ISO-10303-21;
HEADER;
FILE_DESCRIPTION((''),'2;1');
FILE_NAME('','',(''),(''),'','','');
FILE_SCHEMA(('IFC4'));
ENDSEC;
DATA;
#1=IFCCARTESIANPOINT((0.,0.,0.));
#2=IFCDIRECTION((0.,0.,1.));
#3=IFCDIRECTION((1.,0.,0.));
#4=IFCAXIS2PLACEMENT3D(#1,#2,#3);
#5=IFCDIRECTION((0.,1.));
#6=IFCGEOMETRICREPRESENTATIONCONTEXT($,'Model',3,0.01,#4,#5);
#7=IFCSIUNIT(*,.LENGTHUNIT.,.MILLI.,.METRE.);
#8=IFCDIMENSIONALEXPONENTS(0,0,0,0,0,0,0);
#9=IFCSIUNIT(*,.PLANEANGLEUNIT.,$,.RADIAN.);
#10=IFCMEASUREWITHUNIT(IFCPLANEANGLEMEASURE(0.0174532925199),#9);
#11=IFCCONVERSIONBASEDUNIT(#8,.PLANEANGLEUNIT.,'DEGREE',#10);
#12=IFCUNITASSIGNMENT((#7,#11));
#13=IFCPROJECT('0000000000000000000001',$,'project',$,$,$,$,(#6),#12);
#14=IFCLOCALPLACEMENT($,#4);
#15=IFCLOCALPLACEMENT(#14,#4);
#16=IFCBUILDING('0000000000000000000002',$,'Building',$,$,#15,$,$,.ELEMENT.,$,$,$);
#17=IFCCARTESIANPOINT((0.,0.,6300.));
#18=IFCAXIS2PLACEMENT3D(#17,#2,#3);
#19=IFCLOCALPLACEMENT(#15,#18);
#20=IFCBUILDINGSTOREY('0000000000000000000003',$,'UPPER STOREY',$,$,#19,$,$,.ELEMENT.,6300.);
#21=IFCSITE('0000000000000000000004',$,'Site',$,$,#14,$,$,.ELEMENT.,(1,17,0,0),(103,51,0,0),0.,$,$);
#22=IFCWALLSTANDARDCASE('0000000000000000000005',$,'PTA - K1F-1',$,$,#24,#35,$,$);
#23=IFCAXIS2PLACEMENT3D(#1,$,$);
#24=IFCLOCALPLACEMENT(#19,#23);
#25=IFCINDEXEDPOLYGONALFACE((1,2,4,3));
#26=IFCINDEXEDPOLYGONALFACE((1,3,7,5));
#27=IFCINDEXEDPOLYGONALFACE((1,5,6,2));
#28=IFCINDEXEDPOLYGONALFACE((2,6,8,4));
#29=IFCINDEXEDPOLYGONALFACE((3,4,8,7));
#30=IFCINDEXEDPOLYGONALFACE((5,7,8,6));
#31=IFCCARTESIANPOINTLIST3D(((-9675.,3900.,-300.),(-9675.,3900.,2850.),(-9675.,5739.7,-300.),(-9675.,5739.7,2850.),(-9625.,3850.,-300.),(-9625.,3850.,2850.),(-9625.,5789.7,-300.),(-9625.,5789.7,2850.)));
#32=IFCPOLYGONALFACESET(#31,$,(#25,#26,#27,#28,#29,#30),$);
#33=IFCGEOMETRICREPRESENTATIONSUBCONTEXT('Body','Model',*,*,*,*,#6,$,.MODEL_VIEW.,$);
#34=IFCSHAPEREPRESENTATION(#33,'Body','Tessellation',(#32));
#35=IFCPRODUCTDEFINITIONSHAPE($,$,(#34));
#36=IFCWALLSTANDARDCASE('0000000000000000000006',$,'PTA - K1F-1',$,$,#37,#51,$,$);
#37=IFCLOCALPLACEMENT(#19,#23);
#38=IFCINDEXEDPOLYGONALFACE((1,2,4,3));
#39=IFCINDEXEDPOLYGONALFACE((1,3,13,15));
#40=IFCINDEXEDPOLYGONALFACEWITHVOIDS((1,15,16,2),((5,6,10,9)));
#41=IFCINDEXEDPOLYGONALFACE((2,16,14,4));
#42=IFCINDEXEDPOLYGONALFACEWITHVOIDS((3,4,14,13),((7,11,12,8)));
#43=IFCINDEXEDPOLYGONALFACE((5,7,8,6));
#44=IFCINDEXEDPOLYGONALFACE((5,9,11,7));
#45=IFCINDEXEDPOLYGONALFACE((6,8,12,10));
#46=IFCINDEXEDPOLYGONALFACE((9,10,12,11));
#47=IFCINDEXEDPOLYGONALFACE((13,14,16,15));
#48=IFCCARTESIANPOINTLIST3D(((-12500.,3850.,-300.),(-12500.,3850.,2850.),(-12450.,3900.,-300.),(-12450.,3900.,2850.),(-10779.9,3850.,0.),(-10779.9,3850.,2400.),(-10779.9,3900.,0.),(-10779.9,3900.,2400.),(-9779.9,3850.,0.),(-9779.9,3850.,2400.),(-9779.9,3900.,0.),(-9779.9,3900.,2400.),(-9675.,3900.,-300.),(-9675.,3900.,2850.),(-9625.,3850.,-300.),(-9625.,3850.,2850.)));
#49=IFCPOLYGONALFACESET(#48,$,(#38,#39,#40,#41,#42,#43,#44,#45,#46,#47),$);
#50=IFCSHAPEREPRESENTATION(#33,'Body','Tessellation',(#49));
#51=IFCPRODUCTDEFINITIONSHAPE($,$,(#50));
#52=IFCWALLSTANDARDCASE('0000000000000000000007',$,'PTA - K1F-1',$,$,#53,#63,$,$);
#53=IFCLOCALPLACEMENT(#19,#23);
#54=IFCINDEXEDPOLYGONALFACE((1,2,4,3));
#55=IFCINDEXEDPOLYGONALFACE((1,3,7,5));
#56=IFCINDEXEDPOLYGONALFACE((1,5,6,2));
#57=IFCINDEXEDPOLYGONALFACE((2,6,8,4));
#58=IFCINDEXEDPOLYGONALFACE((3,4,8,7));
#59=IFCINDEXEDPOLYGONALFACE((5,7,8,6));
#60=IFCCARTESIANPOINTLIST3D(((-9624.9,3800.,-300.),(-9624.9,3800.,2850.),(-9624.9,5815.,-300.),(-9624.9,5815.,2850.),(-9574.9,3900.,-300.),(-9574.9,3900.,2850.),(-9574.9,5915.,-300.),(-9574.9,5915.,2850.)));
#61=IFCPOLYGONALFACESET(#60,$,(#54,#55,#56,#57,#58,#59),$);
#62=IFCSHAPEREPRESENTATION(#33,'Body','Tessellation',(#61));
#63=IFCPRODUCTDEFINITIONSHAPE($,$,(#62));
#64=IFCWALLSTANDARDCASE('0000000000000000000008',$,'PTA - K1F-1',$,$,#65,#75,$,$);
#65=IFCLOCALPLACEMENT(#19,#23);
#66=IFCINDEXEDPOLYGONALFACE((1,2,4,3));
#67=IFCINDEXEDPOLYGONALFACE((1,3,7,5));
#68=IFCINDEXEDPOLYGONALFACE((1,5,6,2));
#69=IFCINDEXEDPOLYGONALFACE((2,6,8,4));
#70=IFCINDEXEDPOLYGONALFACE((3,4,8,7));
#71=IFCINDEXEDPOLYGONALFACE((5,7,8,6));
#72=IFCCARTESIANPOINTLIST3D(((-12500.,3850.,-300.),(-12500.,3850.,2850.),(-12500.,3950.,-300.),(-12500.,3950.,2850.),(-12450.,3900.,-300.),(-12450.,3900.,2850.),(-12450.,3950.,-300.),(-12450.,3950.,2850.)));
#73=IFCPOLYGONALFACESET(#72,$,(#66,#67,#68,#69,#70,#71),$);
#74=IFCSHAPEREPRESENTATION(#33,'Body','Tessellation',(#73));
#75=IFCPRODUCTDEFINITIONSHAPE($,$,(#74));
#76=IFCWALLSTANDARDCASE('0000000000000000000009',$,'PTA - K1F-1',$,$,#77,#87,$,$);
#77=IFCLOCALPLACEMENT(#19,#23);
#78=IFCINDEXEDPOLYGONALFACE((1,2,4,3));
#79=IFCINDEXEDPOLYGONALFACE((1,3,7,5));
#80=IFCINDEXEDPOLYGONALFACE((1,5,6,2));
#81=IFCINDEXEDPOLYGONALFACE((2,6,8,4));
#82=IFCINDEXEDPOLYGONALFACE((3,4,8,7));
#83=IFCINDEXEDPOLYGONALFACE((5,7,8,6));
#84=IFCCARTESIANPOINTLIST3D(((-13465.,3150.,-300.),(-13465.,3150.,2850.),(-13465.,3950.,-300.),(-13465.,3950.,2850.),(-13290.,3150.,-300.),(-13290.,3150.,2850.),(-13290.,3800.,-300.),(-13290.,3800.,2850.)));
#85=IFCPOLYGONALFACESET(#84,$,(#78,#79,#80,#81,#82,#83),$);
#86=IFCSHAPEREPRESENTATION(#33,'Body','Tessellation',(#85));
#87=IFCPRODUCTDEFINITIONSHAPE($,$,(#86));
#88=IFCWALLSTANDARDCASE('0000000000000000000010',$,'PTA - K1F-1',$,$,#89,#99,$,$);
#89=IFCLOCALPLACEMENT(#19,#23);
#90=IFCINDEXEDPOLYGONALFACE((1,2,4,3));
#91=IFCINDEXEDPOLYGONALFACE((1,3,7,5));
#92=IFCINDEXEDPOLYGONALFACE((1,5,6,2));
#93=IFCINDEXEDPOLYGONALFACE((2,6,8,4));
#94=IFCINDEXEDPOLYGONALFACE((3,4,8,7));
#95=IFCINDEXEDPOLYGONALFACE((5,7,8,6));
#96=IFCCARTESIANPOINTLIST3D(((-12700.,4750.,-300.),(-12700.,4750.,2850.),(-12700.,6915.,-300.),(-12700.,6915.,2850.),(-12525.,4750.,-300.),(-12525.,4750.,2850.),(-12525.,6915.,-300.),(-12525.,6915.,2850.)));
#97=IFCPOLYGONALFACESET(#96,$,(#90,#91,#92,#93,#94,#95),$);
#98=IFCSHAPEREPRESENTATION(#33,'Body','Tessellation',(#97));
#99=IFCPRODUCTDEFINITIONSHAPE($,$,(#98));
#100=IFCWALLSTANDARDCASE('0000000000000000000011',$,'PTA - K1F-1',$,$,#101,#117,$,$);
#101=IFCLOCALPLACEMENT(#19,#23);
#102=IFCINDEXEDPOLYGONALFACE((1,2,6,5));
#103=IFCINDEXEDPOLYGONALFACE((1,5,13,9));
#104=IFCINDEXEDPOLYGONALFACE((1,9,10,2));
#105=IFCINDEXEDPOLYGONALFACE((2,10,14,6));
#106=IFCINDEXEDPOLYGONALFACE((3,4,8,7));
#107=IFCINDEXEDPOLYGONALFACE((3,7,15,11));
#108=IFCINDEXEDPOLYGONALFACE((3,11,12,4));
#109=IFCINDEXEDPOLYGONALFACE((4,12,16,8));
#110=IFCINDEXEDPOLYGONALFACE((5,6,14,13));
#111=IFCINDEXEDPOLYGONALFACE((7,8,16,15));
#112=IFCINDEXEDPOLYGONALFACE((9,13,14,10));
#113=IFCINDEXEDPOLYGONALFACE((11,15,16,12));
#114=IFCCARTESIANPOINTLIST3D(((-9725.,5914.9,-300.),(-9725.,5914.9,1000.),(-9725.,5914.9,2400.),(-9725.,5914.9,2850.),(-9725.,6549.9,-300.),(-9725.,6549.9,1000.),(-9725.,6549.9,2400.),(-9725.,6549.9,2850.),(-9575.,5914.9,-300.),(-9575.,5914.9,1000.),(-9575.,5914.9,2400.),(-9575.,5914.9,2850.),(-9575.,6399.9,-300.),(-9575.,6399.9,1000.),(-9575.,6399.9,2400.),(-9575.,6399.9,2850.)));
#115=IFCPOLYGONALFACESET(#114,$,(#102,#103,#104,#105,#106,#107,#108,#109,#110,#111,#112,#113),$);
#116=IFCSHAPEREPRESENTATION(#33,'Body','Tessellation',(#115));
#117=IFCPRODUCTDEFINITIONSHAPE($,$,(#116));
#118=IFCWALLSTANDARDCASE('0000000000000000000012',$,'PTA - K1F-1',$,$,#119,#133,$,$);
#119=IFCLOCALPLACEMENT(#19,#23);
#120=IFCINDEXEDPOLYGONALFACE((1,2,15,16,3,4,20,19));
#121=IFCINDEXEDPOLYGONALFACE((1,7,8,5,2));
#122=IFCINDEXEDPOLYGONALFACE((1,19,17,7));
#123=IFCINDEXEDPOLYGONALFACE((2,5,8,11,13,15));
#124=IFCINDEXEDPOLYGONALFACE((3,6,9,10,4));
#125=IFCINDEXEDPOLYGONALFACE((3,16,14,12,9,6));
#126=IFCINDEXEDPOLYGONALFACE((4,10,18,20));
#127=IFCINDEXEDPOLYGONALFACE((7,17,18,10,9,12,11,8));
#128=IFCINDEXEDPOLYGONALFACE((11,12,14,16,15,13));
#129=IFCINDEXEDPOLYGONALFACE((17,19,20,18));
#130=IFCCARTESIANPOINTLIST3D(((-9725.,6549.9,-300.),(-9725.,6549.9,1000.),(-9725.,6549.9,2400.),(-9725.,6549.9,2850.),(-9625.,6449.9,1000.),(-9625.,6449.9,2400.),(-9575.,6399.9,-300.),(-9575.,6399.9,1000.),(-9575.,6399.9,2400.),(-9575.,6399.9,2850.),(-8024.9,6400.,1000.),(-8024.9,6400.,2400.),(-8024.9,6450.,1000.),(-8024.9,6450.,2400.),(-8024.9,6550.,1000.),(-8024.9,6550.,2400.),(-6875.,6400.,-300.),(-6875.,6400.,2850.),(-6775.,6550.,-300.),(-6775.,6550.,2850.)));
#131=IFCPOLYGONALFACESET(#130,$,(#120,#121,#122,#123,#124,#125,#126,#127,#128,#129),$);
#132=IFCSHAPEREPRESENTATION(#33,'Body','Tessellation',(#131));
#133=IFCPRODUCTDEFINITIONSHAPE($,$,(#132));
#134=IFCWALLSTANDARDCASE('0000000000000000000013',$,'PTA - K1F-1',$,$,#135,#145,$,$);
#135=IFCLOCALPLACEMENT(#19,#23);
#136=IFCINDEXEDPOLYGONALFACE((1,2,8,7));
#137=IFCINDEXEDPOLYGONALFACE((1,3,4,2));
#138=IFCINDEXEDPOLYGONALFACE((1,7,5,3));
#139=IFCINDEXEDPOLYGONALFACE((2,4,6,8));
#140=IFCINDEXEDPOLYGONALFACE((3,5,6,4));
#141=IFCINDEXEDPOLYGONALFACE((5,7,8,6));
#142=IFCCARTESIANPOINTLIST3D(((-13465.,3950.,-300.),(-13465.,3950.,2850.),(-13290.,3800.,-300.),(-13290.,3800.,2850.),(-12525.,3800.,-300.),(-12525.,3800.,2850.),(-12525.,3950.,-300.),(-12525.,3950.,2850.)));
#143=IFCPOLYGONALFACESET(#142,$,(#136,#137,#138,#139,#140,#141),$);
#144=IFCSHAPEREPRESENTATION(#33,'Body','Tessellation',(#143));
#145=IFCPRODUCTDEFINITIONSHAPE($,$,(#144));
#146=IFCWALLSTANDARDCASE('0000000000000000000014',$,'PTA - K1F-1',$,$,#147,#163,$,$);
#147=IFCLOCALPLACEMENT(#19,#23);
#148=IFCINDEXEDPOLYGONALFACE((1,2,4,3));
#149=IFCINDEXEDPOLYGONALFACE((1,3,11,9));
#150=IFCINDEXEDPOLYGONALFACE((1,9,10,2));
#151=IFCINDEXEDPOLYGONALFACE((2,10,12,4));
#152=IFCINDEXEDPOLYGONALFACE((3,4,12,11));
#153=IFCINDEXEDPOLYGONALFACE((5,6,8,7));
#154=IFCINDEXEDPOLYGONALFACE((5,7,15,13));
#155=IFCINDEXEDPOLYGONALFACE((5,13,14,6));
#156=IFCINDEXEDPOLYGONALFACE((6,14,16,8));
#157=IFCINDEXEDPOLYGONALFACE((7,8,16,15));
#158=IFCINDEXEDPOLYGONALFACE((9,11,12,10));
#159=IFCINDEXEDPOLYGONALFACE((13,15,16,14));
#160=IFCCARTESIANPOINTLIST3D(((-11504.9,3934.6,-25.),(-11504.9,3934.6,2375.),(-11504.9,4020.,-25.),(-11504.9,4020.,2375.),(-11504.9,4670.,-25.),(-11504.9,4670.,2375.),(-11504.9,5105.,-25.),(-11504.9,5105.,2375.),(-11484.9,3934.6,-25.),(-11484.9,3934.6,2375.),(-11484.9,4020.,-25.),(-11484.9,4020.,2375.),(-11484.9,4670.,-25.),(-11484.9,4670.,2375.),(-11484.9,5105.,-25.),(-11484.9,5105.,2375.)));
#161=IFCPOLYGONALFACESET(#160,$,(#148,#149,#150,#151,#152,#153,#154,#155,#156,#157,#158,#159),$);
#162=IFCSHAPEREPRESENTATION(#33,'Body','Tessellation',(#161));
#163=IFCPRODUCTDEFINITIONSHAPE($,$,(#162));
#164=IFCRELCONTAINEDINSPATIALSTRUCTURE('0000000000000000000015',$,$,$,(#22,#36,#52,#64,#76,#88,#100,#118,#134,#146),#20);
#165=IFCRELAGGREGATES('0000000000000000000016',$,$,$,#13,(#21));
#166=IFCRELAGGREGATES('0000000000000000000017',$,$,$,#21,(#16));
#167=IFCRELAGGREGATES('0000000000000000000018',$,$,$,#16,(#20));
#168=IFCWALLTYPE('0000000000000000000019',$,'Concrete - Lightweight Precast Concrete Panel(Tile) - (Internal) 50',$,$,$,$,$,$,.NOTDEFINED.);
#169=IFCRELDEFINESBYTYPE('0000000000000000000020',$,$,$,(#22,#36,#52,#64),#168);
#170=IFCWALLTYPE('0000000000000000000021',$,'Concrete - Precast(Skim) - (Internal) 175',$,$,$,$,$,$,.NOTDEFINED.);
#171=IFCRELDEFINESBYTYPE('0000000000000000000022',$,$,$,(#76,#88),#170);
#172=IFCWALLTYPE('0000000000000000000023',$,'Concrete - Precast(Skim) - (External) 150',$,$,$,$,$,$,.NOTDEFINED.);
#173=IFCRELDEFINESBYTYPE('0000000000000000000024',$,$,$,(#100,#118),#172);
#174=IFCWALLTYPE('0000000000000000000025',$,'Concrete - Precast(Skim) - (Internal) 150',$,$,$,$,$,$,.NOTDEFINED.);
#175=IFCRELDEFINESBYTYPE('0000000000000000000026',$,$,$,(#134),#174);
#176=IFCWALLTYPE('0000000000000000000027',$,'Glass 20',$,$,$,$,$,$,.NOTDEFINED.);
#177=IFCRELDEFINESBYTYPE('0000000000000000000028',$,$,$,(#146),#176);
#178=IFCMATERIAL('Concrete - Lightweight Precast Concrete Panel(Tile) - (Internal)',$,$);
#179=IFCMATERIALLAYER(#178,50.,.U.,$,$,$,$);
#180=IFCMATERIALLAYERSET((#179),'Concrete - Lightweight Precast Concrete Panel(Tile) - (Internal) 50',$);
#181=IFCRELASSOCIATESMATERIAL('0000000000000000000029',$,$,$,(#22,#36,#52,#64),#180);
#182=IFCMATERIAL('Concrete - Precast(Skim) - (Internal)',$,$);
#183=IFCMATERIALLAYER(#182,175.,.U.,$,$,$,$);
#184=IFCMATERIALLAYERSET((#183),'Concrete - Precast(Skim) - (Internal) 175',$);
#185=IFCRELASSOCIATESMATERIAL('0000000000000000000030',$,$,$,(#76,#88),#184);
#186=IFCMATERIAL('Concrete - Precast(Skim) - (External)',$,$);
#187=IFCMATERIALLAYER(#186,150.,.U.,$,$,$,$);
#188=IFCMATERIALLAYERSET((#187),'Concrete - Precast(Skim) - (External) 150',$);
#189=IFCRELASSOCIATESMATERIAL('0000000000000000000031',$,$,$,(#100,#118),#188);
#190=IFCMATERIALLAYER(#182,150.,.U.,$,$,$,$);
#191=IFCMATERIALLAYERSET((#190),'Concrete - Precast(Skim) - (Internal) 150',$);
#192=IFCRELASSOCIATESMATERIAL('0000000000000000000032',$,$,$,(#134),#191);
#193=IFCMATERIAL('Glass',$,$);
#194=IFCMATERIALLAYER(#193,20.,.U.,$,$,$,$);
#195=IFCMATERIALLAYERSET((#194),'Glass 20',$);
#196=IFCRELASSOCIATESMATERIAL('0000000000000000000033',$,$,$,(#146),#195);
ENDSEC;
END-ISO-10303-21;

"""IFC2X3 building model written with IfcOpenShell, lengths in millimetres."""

from ifc_helpers import new_model, entity, si_unit, converted_unit, direction, frame, origin_with_axes, origin_2d_with_axis, place, context, subcontext, project, spatial, polyline, rectangle, outline, extrude, material, layer, layer_set, layer_usage, type_object, element, save


model = new_model("IFC2X3")

# Units and contexts
model_context = context("Model", 3, precision=0.01, world=origin_with_axes(), true_north=direction((0.0, 1.0)))
body_context = subcontext(model_context, "Body", "Model", "MODEL_VIEW")
ifc_project = project(units=[si_unit("LENGTHUNIT", "METRE", prefix="MILLI"), converted_unit("PLANEANGLEUNIT", "DEGREE", entity("IfcPlaneAngleMeasure", 0.0174532925199), si_unit("PLANEANGLEUNIT", "RADIAN"), dimensions=[0, 0, 0, 0, 0, 0, 0])], contexts=[model_context])

# Site, building, storey
site_placement = place(None, origin_with_axes())
site = spatial("IfcSite", under=ifc_project, at=site_placement, Name="Site", CompositionType="ELEMENT", RefLatitude=(1, 17, 0, 0), RefLongitude=(103, 51, 0, 0), RefElevation=0.0)
building_placement = place(site_placement, origin_with_axes())
building = spatial("IfcBuilding", under=site, at=building_placement, Name="Building", CompositionType="ELEMENT")
storey_placement = place(building_placement, frame((0.0, 0.0, 6300.0), z_axis=(0.0, 0.0, 1.0), x_axis=(1.0, 0.0, 0.0)))
storey = spatial("IfcBuildingStorey", under=building, at=storey_placement, Name="UPPER STOREY", CompositionType="ELEMENT", Elevation=6300.0)

# Wall
ifc_material_1 = material(Name="Concrete - Lightweight Precast Concrete Panel(Tile) - (Internal)")
ifc_layer_1 = layer(ifc_material_1, 50.0, ventilated="UNKNOWN")
ifc_layer_set_1 = layer_set([ifc_layer_1], Name="Concrete - Lightweight Precast Concrete Panel(Tile) - (Internal) 50")
wall_type_1 = type_object("IfcWallType", Name="Concrete - Lightweight Precast Concrete Panel(Tile) - (Internal) 50", PredefinedType="NOTDEFINED")
ifc_layer_usage_1 = layer_usage(ifc_layer_set_1, "AXIS2", "POSITIVE", 0.0)
wall_1_placement = place(storey_placement, frame((-9675.0, 5789.7, -300.0), z_axis=(0.0, 0.0, 1.0), x_axis=(0.0, -1.0, 0.0)))
element("IfcWallStandardCase", 1, at=wall_1_placement, inside=storey, type_object=wall_type_1, material=ifc_layer_usage_1, Name="PTA - K1F-1", context=body_context, shape_type="SweptSolid", body=[
    extrude(outline(polyline([(50.0, 0.0), (1889.7, 0.0), (1939.7, 50.0), (0.0, 50.0), (50.0, 0.0)])), origin_with_axes(), (0.0, 0.0, 1.0), 3150.0),
])

# Wall, opening
ifc_layer_usage_2 = layer_usage(ifc_layer_set_1, "AXIS2", "NEGATIVE", 0.0)
wall_2_placement = place(storey_placement, frame((-9675.0, 3850.0, -300.0), z_axis=(0.0, 0.0, 1.0), x_axis=(-1.0, 0.000001, 0.0)))
wall_2 = element("IfcWallStandardCase", 2, at=wall_2_placement, inside=storey, type_object=wall_type_1, material=ifc_layer_usage_2, Name="PTA - K1F-1", context=body_context, shape_type="SweptSolid", body=[
    extrude(outline(polyline([(0.0, -50.0), (2775.0, -50.0), (2825.0, 0.0), (-50.0, 0.0), (0.0, -50.0)])), origin_with_axes(), (0.0, 0.0, 1.0), 3150.0),
])
opening_1_placement = place(wall_2_placement, frame((604.9, 0.0, 300.0), z_axis=(0.0, 0.0, 1.0), x_axis=(1.0, 0.0, 0.0)))
element("IfcOpeningElement", 3, at=opening_1_placement, cuts=wall_2, context=body_context, shape_type="SweptSolid", body=[
    extrude(rectangle(XDim=1000.0, YDim=2400.0, at=origin_2d_with_axis()), frame((0.0, 50.0, 1200.0), z_axis=(0.0, -1.0, 0.0), x_axis=(-1.0, 0.0, 0.0)), (0.0, 0.0, 1.0), 150.0),
])

# Walls
ifc_layer_usage_3 = layer_usage(ifc_layer_set_1, "AXIS2", "NEGATIVE", 0.0)
wall_3_placement = place(storey_placement, frame((-9574.9, 5915.0, -300.0), z_axis=(0.0, 0.0, 1.0), x_axis=(0.0, -1.0, 0.0)))
element("IfcWallStandardCase", 4, at=wall_3_placement, inside=storey, type_object=wall_type_1, material=ifc_layer_usage_3, Name="PTA - K1F-1", context=body_context, shape_type="SweptSolid", body=[
    extrude(outline(polyline([(100.0, -50.0), (2115.0, -50.0), (2015.0, 0.0), (0.0, 0.0), (100.0, -50.0)])), origin_with_axes(), (0.0, 0.0, 1.0), 3150.0),
])
ifc_layer_usage_4 = layer_usage(ifc_layer_set_1, "AXIS2", "NEGATIVE", 0.0)
wall_4_placement = place(storey_placement, frame((-12500.0, 3850.0, -300.0), z_axis=(0.0, 0.0, 1.0), x_axis=(0.0, 1.0, 0.0)))
element("IfcWallStandardCase", 5, at=wall_4_placement, inside=storey, type_object=wall_type_1, material=ifc_layer_usage_4, Name="PTA - K1F-1", context=body_context, shape_type="SweptSolid", body=[
    extrude(outline(polyline([(50.0, -50.0), (100.0, -50.0), (100.0, 0.0), (0.0, 0.0), (50.0, -50.0)])), origin_with_axes(), (0.0, 0.0, 1.0), 3150.0),
])
ifc_material_2 = material(Name="Concrete - Precast(Skim) - (Internal)")
ifc_layer_2 = layer(ifc_material_2, 175.0, ventilated="UNKNOWN")
ifc_layer_set_2 = layer_set([ifc_layer_2], Name="Concrete - Precast(Skim) - (Internal) 175")
ifc_layer_usage_5 = layer_usage(ifc_layer_set_2, "AXIS2", "NEGATIVE", 0.0)
wall_type_2 = type_object("IfcWallType", Name="Concrete - Precast(Skim) - (Internal) 175", PredefinedType="NOTDEFINED")
wall_5_placement = place(storey_placement, frame((-13465.0, 3150.0, -300.0), z_axis=(0.0, 0.0, 1.0), x_axis=(0.0, 1.0, 0.0)))
element("IfcWallStandardCase", 6, at=wall_5_placement, inside=storey, type_object=wall_type_2, material=ifc_layer_usage_5, Name="PTA - K1F-1", context=body_context, shape_type="SweptSolid", body=[
    extrude(outline(polyline([(0.0, -175.0), (650.0, -175.0), (800.0, 0.0), (0.0, 0.0), (0.0, -175.0)])), origin_with_axes(), (0.0, 0.0, 1.0), 3150.0),
])
ifc_layer_usage_6 = layer_usage(ifc_layer_set_2, "AXIS2", "NEGATIVE", 0.0)
wall_6_placement = place(storey_placement, frame((-12700.0, 4750.0, -300.0), z_axis=(0.0, 0.0, 1.0), x_axis=(0.0, 1.0, 0.0)))
element("IfcWallStandardCase", 7, at=wall_6_placement, inside=storey, type_object=wall_type_2, material=ifc_layer_usage_6, Name="PTA - K1F-1", context=body_context, shape_type="SweptSolid", body=[
    extrude(outline(polyline([(0.0, -175.0), (2165.0, -175.0), (2165.0, 0.0), (0.0, 0.0), (0.0, -175.0)])), origin_with_axes(), (0.0, 0.0, 1.0), 3150.0),
])

# Walls, openings
ifc_material_3 = material(Name="Concrete - Precast(Skim) - (External)")
ifc_layer_3 = layer(ifc_material_3, 150.0, ventilated="UNKNOWN")
ifc_layer_set_3 = layer_set([ifc_layer_3], Name="Concrete - Precast(Skim) - (External) 150")
ifc_layer_usage_7 = layer_usage(ifc_layer_set_3, "AXIS2", "NEGATIVE", 0.0)
wall_type_3 = type_object("IfcWallType", Name="Concrete - Precast(Skim) - (External) 150", PredefinedType="NOTDEFINED")
wall_7_placement = place(storey_placement, frame((-9725.0, 5914.9, -300.0), z_axis=(0.0, 0.0, 1.0), x_axis=(0.0, 1.0, 0.0)))
wall_7 = element("IfcWallStandardCase", 8, at=wall_7_placement, inside=storey, type_object=wall_type_3, material=ifc_layer_usage_7, Name="PTA - K1F-1", context=body_context, shape_type="SweptSolid", body=[
    extrude(outline(polyline([(0.0, -150.0), (485.0, -150.0), (635.0, 0.0), (0.0, 0.0), (0.0, -150.0)])), origin_with_axes(), (0.0, 0.0, 1.0), 3150.0),
])
opening_2_placement = place(wall_7_placement, frame((267.5, 0.0, 1300.0), z_axis=(0.0, 0.0, 1.0), x_axis=(1.0, 0.0, 0.0)))
element("IfcOpeningElement", 9, at=opening_2_placement, cuts=wall_7, context=body_context, shape_type="SweptSolid", body=[
    extrude(rectangle(XDim=635.0, YDim=1400.0, at=origin_2d_with_axis()), frame((50.0, -150.0, 700.0), z_axis=(0.0, -1.0, 0.0), x_axis=(-1.0, 0.0, 0.0)), (0.0, 0.0, -1.0), 450.0),
])
ifc_layer_usage_8 = layer_usage(ifc_layer_set_3, "AXIS2", "NEGATIVE", 0.0)
wall_8_placement = place(storey_placement, frame((-9725.0, 6549.9, -300.0), z_axis=(0.0, 0.0, 1.0), x_axis=(1.0, 0.000017, 0.0)))
wall_8 = element("IfcWallStandardCase", 10, at=wall_8_placement, inside=storey, type_object=wall_type_3, material=ifc_layer_usage_8, Name="PTA - K1F-1", context=body_context, shape_type="SweptSolid", body=[
    extrude(outline(polyline([(150.0, -150.0), (2850.0, -150.0), (2950.0, 0.0), (0.0, 0.0), (150.0, -150.0)])), origin_with_axes(), (0.0, 0.0, 1.0), 3150.0),
])
opening_3_placement = place(wall_8_placement, frame((900.1, 0.0, 1300.0), z_axis=(0.0, 0.0, 1.0), x_axis=(1.0, 0.0, 0.0)))
element("IfcOpeningElement", 11, at=opening_3_placement, cuts=wall_8, context=body_context, shape_type="SweptSolid", body=[
    extrude(rectangle(XDim=1700.1, YDim=1400.0, at=origin_2d_with_axis()), frame((-50.0, -100.0, 700.0), z_axis=(0.0, -1.0, 0.0), x_axis=(1.0, 0.0, 0.0)), (0.0, 0.0, -1.0), 250.0),
    extrude(rectangle(XDim=1700.1, YDim=1400.0, at=origin_2d_with_axis()), frame((-50.0, -100.0, 700.0), z_axis=(0.0, 1.0, 0.0), x_axis=(1.0, 0.0, 0.0)), (0.0, 0.0, -1.0), 200.0),
])

# Wall
ifc_layer_4 = layer(ifc_material_2, 150.0, ventilated="UNKNOWN")
ifc_layer_set_4 = layer_set([ifc_layer_4], Name="Concrete - Precast(Skim) - (Internal) 150")
ifc_layer_usage_9 = layer_usage(ifc_layer_set_4, "AXIS2", "NEGATIVE", 0.0)
wall_type_4 = type_object("IfcWallType", Name="Concrete - Precast(Skim) - (Internal) 150", PredefinedType="NOTDEFINED")
wall_9_placement = place(storey_placement, frame((-13465.0, 3950.0, -300.0), z_axis=(0.0, 0.0, 1.0), x_axis=(1.0, 0.0, 0.0)))
element("IfcWallStandardCase", 12, at=wall_9_placement, inside=storey, type_object=wall_type_4, material=ifc_layer_usage_9, Name="PTA - K1F-1", context=body_context, shape_type="SweptSolid", body=[
    extrude(outline(polyline([(175.0, -150.0), (940.0, -150.0), (940.0, 0.0), (0.0, 0.0), (175.0, -150.0)])), origin_with_axes(), (0.0, 0.0, 1.0), 3150.0),
])

# Wall, opening
ifc_material_4 = material(Name="Glass")
ifc_layer_5 = layer(ifc_material_4, 20.0, ventilated="UNKNOWN")
ifc_layer_set_5 = layer_set([ifc_layer_5], Name="Glass 20")
ifc_layer_usage_10 = layer_usage(ifc_layer_set_5, "AXIS2", "POSITIVE", 0.0)
wall_type_5 = type_object("IfcWallType", Name="Glass 20", PredefinedType="NOTDEFINED")
wall_10_placement = place(storey_placement, frame((-11484.9, 3934.6, -25.0), z_axis=(0.0, 0.0, 1.0), x_axis=(0.000059, 1.0, 0.0)))
wall_10 = element("IfcWallStandardCase", 13, at=wall_10_placement, inside=storey, type_object=wall_type_5, material=ifc_layer_usage_10, Name="PTA - K1F-1", context=body_context, shape_type="SweptSolid", body=[
    extrude(outline(polyline([(0.0, 0.0), (1170.4, 0.0), (1170.4, 20.0), (0.0, 20.0), (0.0, 0.0)])), origin_with_axes(), (0.0, 0.0, 1.0), 2400.0),
])
opening_4_placement = place(wall_10_placement, frame((410.4, 0.0, 0.0), z_axis=(0.0, 0.0, 1.0), x_axis=(1.0, 0.0, 0.0)))
element("IfcOpeningElement", 14, at=opening_4_placement, cuts=wall_10, context=body_context, shape_type="SweptSolid", body=[
    extrude(rectangle(XDim=650.0, YDim=2400.0, at=origin_2d_with_axis()), frame((0.0, -20.0, 1200.0), z_axis=(0.0, 1.0, 0.0), x_axis=(-1.0, 0.0, 0.0)), (0.0, 0.0, 1.0), 60.0),
])

save(model, "model.ifc")
